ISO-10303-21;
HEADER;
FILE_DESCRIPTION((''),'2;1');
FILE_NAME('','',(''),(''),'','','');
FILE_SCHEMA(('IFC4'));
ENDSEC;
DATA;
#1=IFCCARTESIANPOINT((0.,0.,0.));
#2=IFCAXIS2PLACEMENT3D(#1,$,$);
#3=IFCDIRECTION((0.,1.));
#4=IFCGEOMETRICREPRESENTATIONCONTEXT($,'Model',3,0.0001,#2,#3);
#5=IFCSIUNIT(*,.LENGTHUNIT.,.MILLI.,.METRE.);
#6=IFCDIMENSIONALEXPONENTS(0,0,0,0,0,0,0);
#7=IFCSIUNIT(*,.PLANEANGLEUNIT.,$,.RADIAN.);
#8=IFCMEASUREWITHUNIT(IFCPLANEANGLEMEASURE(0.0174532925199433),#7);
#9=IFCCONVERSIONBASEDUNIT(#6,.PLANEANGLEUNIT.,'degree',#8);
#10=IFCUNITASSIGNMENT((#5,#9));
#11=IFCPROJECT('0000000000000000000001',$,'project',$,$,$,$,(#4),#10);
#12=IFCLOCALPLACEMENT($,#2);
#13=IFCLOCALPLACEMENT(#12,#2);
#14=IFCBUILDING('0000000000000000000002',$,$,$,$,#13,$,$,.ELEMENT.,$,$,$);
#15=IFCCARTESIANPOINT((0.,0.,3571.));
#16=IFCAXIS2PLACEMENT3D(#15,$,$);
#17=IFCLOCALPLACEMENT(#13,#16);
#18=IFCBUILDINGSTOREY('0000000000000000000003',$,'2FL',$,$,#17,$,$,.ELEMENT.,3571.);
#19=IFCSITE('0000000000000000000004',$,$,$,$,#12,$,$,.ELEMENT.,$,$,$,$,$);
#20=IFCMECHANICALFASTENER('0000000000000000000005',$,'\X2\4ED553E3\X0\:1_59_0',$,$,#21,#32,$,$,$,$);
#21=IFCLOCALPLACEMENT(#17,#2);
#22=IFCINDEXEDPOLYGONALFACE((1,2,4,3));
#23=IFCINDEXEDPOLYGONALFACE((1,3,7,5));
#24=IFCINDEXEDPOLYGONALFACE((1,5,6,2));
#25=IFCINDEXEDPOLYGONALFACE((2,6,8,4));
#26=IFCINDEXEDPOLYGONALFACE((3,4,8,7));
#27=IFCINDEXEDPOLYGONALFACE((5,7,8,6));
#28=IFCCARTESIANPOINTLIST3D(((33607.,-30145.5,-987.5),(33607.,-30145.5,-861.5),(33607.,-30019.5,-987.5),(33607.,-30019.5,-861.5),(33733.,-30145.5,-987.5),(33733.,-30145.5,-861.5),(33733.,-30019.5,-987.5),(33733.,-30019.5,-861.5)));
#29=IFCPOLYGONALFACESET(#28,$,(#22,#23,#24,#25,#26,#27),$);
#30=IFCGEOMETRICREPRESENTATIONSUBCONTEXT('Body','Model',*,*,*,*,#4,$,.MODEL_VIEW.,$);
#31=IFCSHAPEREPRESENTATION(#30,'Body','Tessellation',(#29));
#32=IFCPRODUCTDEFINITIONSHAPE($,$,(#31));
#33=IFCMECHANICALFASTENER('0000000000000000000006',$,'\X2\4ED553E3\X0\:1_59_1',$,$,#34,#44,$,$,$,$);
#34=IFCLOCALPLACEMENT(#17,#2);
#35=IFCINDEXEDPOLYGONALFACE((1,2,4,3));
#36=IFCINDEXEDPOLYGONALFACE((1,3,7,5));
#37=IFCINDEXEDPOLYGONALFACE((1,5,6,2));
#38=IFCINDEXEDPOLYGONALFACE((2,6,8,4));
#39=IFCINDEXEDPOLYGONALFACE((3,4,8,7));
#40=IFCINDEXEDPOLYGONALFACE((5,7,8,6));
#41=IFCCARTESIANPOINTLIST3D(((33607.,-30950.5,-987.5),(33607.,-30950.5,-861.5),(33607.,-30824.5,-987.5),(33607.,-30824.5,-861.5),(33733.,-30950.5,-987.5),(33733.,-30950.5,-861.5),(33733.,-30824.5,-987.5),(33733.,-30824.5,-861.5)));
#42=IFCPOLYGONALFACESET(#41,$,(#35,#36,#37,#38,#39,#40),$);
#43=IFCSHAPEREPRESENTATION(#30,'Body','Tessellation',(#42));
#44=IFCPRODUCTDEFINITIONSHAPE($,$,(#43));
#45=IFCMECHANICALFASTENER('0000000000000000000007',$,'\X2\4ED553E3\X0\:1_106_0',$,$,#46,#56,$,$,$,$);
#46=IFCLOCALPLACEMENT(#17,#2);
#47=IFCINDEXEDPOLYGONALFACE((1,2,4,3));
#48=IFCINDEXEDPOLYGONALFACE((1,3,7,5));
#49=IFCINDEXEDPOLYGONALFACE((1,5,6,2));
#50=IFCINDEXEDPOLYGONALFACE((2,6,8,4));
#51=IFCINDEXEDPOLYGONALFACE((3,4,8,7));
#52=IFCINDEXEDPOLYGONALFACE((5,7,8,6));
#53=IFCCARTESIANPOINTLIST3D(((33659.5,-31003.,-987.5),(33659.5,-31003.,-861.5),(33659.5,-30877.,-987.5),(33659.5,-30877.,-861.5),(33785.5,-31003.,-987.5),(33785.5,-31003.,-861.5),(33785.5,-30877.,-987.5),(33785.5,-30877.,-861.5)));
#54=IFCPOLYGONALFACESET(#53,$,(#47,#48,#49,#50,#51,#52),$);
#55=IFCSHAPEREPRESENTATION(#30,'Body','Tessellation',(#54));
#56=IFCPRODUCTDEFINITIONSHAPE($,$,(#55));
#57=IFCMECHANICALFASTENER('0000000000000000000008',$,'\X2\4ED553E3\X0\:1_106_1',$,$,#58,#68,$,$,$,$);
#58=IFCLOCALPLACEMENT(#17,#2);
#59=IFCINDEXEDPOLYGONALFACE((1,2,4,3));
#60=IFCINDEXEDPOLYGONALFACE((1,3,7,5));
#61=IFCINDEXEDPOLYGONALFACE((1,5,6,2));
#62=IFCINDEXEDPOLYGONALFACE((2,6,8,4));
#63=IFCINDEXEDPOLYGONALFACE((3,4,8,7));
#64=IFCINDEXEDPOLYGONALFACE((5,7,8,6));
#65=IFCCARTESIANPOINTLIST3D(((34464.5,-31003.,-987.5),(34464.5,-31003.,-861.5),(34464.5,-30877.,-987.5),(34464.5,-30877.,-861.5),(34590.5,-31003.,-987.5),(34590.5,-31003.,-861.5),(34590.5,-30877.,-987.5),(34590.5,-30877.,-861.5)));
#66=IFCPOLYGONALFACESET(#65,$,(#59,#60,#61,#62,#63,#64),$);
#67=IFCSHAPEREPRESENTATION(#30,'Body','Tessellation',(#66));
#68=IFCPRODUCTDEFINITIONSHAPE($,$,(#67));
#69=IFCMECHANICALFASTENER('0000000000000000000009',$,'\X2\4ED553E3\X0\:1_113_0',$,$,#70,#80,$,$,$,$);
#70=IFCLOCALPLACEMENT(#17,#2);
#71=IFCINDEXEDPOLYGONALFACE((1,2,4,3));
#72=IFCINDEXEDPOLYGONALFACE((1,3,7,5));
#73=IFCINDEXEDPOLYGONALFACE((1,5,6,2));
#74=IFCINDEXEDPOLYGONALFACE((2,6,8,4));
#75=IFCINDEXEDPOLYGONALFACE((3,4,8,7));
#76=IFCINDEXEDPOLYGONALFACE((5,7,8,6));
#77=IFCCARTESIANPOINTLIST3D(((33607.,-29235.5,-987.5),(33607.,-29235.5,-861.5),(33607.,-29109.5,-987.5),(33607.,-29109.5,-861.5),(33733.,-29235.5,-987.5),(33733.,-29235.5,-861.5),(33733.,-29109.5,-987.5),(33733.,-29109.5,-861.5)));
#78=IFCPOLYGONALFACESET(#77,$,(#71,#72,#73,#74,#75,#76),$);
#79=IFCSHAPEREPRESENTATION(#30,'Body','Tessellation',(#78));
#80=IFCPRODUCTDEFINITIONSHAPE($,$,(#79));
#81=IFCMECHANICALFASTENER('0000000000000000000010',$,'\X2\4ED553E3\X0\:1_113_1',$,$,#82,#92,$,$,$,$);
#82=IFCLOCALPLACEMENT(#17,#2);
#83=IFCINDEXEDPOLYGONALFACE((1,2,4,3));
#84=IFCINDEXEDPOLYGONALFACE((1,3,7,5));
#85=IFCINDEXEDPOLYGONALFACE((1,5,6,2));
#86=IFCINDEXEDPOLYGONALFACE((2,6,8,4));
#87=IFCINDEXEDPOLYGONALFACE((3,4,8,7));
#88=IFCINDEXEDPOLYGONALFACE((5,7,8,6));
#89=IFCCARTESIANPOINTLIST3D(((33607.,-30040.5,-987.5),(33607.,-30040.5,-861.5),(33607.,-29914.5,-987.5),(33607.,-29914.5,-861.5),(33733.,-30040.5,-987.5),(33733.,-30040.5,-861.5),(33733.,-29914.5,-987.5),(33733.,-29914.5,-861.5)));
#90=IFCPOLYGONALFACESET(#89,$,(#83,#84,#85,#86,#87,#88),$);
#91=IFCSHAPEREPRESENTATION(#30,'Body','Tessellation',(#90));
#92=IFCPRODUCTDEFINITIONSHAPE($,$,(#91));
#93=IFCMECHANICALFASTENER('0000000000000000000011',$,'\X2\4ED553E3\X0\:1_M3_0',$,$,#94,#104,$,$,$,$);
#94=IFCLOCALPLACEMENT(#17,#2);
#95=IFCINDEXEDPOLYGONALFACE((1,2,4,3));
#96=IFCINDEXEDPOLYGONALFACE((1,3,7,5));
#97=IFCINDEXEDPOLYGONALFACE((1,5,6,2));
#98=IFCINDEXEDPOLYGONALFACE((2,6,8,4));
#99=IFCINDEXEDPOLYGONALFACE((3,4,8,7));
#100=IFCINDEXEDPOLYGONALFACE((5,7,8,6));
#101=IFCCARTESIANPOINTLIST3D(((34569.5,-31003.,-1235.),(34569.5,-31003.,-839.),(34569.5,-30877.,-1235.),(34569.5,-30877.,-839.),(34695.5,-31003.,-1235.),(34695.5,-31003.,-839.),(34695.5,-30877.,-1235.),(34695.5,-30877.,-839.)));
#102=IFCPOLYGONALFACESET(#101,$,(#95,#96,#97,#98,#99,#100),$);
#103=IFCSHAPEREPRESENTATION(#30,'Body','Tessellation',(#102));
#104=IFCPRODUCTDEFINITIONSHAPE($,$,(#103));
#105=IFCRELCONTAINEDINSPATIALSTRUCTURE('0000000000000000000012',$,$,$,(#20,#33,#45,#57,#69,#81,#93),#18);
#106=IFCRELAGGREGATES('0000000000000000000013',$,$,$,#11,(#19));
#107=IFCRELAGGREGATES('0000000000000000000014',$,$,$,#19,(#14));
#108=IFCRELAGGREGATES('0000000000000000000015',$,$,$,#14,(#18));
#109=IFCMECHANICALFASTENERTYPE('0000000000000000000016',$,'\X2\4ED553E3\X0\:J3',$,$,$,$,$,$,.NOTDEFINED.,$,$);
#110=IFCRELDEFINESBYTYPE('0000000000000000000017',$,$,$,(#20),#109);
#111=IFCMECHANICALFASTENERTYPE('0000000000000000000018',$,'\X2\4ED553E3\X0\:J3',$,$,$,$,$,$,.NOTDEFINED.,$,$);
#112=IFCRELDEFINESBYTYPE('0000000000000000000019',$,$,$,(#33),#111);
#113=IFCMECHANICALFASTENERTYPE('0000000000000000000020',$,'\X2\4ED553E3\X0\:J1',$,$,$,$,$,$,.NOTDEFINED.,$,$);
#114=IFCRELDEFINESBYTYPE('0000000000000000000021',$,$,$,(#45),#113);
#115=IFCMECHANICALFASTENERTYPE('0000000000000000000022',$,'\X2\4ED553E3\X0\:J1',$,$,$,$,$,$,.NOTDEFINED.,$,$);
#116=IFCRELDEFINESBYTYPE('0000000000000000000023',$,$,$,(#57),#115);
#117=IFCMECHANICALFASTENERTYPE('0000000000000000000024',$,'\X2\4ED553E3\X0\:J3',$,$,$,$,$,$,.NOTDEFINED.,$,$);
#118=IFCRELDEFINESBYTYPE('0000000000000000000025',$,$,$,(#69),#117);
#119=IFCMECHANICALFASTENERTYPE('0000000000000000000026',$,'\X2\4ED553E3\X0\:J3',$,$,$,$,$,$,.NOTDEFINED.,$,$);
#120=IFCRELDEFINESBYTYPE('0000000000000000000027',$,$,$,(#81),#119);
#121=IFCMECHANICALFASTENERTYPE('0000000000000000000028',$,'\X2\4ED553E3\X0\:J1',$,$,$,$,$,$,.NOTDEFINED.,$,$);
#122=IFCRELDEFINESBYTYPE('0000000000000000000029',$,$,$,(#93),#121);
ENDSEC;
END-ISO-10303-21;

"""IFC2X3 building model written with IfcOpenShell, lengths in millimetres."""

from ifc_helpers import new_model, entity, si_unit, converted_unit, direction, frame, origin, origin_with_axes, origin_2d, place, context, subcontext, project, spatial, rectangle, extrude, type_object, element, save


model = new_model("IFC2X3")

# Units and contexts
model_context = context("Model", 3, precision=0.0001, world=origin(), true_north=direction((0.0, 1.0)))
body_context = subcontext(model_context, "Body", "Model", "MODEL_VIEW")
ifc_project = project(units=[si_unit("LENGTHUNIT", "METRE", prefix="MILLI"), converted_unit("PLANEANGLEUNIT", "degree", entity("IfcPlaneAngleMeasure", 0.0174532925199433), si_unit("PLANEANGLEUNIT", "RADIAN"), dimensions=[0, 0, 0, 0, 0, 0, 0])], contexts=[model_context])

# Site, building, storey
site_placement = place(None, origin())
site = spatial("IfcSite", under=ifc_project, at=site_placement, CompositionType="ELEMENT")
building_placement = place(site_placement, origin())
building = spatial("IfcBuilding", under=site, at=building_placement, CompositionType="ELEMENT")
storey_placement = place(building_placement, frame((0.0, 0.0, 3571.0)))
storey = spatial("IfcBuildingStorey", under=building, at=storey_placement, Name="2FL", CompositionType="ELEMENT", Elevation=3571.0)

# Mechanical fasteners
mechanical_fastener_type_1 = type_object("IfcMechanicalFastenerType", Name="仕口:J3")
mechanical_fastener_1_placement = place(storey_placement, frame((33670.0, -30082.5, -987.5)))
element("IfcMechanicalFastener", 1, at=mechanical_fastener_1_placement, inside=storey, type_object=mechanical_fastener_type_1, Name="仕口:1_59_0", context=body_context, shape_type="SweptSolid", body=[
    extrude(rectangle(XDim=126.0, YDim=126.0, at=origin_2d()), origin_with_axes(), (0.0, 0.0, 1.0), 126.0),
])
mechanical_fastener_type_2 = type_object("IfcMechanicalFastenerType", Name="仕口:J3")
mechanical_fastener_2_placement = place(storey_placement, frame((33670.0, -30887.5, -987.5)))
element("IfcMechanicalFastener", 2, at=mechanical_fastener_2_placement, inside=storey, type_object=mechanical_fastener_type_2, Name="仕口:1_59_1", context=body_context, shape_type="SweptSolid", body=[
    extrude(rectangle(XDim=126.0, YDim=126.0, at=origin_2d()), origin_with_axes(), (0.0, 0.0, 1.0), 126.0),
])
mechanical_fastener_type_3 = type_object("IfcMechanicalFastenerType", Name="仕口:J1")
mechanical_fastener_3_placement = place(storey_placement, frame((33722.5, -30940.0, -987.5)))
element("IfcMechanicalFastener", 3, at=mechanical_fastener_3_placement, inside=storey, type_object=mechanical_fastener_type_3, Name="仕口:1_106_0", context=body_context, shape_type="SweptSolid", body=[
    extrude(rectangle(XDim=126.0, YDim=126.0, at=origin_2d()), origin_with_axes(), (0.0, 0.0, 1.0), 126.0),
])
mechanical_fastener_type_4 = type_object("IfcMechanicalFastenerType", Name="仕口:J1")
mechanical_fastener_4_placement = place(storey_placement, frame((34527.5, -30940.0, -987.5)))
element("IfcMechanicalFastener", 4, at=mechanical_fastener_4_placement, inside=storey, type_object=mechanical_fastener_type_4, Name="仕口:1_106_1", context=body_context, shape_type="SweptSolid", body=[
    extrude(rectangle(XDim=126.0, YDim=126.0, at=origin_2d()), origin_with_axes(), (0.0, 0.0, 1.0), 126.0),
])
mechanical_fastener_type_5 = type_object("IfcMechanicalFastenerType", Name="仕口:J3")
mechanical_fastener_5_placement = place(storey_placement, frame((33670.0, -29172.5, -987.5)))
element("IfcMechanicalFastener", 5, at=mechanical_fastener_5_placement, inside=storey, type_object=mechanical_fastener_type_5, Name="仕口:1_113_0", context=body_context, shape_type="SweptSolid", body=[
    extrude(rectangle(XDim=126.0, YDim=126.0, at=origin_2d()), origin_with_axes(), (0.0, 0.0, 1.0), 126.0),
])
mechanical_fastener_type_6 = type_object("IfcMechanicalFastenerType", Name="仕口:J3")
mechanical_fastener_6_placement = place(storey_placement, frame((33670.0, -29977.5, -987.5)))
element("IfcMechanicalFastener", 6, at=mechanical_fastener_6_placement, inside=storey, type_object=mechanical_fastener_type_6, Name="仕口:1_113_1", context=body_context, shape_type="SweptSolid", body=[
    extrude(rectangle(XDim=126.0, YDim=126.0, at=origin_2d()), origin_with_axes(), (0.0, 0.0, 1.0), 126.0),
])
mechanical_fastener_type_7 = type_object("IfcMechanicalFastenerType", Name="仕口:J1")
mechanical_fastener_7_placement = place(storey_placement, frame((34632.5, -30940.0, -1235.0)))
element("IfcMechanicalFastener", 7, at=mechanical_fastener_7_placement, inside=storey, type_object=mechanical_fastener_type_7, Name="仕口:1_M3_0", context=body_context, shape_type="SweptSolid", body=[
    extrude(rectangle(XDim=126.0, YDim=126.0, at=origin_2d()), origin_with_axes(), (0.0, 0.0, 1.0), 396.0),
])

save(model, "model.ifc")
